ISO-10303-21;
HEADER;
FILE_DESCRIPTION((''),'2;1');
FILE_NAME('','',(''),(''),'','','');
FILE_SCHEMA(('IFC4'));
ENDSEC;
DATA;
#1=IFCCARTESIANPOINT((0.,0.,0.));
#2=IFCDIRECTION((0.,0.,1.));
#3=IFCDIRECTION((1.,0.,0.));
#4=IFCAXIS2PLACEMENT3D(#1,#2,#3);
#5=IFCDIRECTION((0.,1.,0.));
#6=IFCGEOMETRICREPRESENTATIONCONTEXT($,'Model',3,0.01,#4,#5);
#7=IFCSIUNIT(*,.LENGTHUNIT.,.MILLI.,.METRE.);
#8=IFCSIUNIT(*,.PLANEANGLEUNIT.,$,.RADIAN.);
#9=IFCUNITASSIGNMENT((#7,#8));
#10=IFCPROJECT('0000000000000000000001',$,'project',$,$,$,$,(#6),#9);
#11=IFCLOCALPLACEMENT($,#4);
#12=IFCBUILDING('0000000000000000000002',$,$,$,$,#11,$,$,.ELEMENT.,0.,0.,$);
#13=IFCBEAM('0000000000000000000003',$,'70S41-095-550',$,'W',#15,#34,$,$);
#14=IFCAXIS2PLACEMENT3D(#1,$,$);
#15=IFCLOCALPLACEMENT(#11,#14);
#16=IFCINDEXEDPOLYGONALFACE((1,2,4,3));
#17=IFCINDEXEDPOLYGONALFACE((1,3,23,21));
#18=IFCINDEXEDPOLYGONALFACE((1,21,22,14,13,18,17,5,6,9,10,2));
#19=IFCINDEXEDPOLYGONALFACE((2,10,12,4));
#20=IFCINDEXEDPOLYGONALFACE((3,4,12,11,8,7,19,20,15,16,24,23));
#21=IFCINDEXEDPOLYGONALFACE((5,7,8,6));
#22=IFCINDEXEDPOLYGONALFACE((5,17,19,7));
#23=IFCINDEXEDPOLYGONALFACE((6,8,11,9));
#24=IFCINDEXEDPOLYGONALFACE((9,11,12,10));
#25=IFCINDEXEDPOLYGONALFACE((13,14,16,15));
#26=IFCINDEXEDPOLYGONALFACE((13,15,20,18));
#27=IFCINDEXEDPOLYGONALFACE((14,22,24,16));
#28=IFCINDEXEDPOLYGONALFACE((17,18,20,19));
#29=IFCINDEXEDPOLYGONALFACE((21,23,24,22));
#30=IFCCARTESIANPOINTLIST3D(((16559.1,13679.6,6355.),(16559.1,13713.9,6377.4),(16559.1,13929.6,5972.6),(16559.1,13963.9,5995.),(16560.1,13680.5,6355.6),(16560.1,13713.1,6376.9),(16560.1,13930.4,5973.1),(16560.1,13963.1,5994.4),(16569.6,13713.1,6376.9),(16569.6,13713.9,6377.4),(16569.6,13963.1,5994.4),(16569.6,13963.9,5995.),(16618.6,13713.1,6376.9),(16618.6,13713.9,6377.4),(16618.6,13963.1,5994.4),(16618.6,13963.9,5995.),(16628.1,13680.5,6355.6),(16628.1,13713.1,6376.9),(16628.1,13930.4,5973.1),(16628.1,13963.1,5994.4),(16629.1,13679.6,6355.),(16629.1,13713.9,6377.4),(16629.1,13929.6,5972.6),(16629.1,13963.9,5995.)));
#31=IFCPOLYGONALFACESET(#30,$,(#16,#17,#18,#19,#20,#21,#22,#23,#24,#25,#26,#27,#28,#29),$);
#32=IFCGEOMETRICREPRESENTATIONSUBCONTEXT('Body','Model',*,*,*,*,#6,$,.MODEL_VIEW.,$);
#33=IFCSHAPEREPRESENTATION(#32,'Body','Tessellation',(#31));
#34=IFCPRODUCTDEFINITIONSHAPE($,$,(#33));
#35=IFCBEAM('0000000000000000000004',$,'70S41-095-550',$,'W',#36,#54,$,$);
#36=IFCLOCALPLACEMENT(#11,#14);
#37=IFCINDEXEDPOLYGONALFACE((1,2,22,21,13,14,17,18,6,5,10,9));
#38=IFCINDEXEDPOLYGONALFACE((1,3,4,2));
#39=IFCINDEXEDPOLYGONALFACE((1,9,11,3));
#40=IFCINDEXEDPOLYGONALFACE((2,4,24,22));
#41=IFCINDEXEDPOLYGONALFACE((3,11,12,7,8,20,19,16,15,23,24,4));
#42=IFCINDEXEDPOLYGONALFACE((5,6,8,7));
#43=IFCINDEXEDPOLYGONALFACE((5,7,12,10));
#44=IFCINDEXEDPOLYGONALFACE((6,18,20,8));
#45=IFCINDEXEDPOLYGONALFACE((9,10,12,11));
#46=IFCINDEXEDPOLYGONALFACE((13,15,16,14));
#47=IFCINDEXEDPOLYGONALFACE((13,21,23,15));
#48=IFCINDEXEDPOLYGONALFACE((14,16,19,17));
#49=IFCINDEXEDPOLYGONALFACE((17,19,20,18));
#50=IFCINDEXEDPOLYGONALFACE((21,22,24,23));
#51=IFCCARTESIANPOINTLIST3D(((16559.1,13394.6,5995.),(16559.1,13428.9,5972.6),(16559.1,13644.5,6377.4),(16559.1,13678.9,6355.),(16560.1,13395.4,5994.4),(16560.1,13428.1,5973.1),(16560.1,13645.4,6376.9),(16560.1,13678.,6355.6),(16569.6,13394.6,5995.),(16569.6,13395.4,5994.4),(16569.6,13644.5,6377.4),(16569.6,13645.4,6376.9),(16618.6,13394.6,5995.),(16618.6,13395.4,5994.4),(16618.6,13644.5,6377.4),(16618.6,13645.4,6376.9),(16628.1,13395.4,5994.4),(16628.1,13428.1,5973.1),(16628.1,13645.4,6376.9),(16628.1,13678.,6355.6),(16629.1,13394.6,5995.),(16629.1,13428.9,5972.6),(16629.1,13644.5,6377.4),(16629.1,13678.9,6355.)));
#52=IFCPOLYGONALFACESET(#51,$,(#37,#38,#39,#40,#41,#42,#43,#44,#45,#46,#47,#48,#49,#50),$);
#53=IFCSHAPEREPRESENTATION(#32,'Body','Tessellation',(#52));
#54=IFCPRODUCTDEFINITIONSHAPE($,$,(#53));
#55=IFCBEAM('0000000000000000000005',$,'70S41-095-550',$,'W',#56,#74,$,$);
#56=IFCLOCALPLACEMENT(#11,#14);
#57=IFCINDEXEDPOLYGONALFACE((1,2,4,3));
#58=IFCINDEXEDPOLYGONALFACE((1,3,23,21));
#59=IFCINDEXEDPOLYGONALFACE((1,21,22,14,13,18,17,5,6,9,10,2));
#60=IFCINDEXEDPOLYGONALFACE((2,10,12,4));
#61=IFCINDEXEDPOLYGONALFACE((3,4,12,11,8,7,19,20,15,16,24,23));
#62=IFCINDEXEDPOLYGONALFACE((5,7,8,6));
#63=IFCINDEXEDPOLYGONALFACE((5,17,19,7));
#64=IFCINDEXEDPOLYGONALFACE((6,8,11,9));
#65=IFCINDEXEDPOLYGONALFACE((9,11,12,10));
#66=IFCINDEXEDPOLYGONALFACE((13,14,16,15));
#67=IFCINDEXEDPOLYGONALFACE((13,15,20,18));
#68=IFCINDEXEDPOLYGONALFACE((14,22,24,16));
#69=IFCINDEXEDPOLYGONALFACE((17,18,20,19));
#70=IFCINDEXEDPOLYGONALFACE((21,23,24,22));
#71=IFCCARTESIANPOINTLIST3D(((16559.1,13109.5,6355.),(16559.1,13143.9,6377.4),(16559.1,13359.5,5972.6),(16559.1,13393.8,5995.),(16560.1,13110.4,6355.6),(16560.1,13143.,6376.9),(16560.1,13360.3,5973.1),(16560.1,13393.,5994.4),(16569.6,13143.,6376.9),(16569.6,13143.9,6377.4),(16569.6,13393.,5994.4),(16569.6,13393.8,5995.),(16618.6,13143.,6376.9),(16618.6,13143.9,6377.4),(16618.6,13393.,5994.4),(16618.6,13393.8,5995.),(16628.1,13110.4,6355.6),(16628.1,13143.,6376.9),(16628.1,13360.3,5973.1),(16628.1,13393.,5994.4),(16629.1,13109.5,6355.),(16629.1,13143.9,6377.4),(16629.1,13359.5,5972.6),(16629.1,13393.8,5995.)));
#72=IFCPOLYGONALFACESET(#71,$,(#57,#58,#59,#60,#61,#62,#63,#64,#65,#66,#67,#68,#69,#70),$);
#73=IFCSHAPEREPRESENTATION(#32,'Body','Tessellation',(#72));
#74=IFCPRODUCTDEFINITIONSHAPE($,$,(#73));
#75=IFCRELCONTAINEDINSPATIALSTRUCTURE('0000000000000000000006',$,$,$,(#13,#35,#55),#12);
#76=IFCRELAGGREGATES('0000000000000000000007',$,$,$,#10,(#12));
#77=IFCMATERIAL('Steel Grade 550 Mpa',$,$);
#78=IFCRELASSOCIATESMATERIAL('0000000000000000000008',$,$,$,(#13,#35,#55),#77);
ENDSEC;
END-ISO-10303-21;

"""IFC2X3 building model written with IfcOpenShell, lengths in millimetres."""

from ifc_helpers import new_model, si_unit, direction, frame, origin, origin_with_axes, origin_2d_with_axis, place, context, subcontext, project, spatial, c_section, extrude, source, transform, mapped, material, element, save


model = new_model("IFC2X3")

# Units and contexts
model_context = context("Model", 3, precision=0.01, world=origin_with_axes(), true_north=direction((0.0, 1.0, 0.0)))
body_context = subcontext(model_context, "Body", "Model", "MODEL_VIEW")
ifc_project = project(units=[si_unit("LENGTHUNIT", "METRE", prefix="MILLI"), si_unit("PLANEANGLEUNIT", "RADIAN")], contexts=[model_context])

# Building
building_placement = place(None, origin_with_axes())
building = spatial("IfcBuilding", under=ifc_project, at=building_placement, CompositionType="ELEMENT", ElevationOfRefHeight=0.0, ElevationOfTerrain=0.0)

# Shared definitions
ifc_material = material(Name="Steel Grade 550 Mpa")

# Beams
shared_shape_1 = source(origin(), body_context, "Body", "SweptSolid", [
    extrude(c_section(Depth=70.0, Width=41.0, WallThickness=1.0, Girth=10.5, at=origin_2d_with_axis()), origin_with_axes(), (0.0, 0.0, 1.0), 456.9),
])
beam_1_placement = place(None, frame((16594.1, 13696.8, 6366.2), z_axis=(0.0, 0.547116, -0.837057), x_axis=(0.0, 0.837057, 0.547116)))
element("IfcBeam", 1, at=beam_1_placement, inside=building, material=ifc_material, Name="70S41-095-550", ObjectType="W", context=body_context, shape_type="MappedRepresentation", body=[
    mapped(shared_shape_1, transform((0.0, 0.0, 0.0), scale=1.0)),
])
shared_shape_2 = source(origin(), body_context, "Body", "SweptSolid", [
    extrude(c_section(Depth=70.0, Width=41.0, WallThickness=1.0, Girth=10.5, at=origin_2d_with_axis()), origin_with_axes(), (0.0, 0.0, 1.0), 456.9),
])
beam_2_placement = place(None, frame((16594.1, 13411.7, 5983.8), z_axis=(0.0, 0.547116, 0.837057), x_axis=(0.0, -0.837057, 0.547116)))
element("IfcBeam", 2, at=beam_2_placement, inside=building, material=ifc_material, Name="70S41-095-550", ObjectType="W", context=body_context, shape_type="MappedRepresentation", body=[
    mapped(shared_shape_2, transform((0.0, 0.0, 0.0), scale=1.0)),
])
shared_shape_3 = source(origin(), body_context, "Body", "SweptSolid", [
    extrude(c_section(Depth=70.0, Width=41.0, WallThickness=1.0, Girth=10.5, at=origin_2d_with_axis()), origin_with_axes(), (0.0, 0.0, 1.0), 456.9),
])
beam_3_placement = place(None, frame((16594.1, 13126.7, 6366.2), z_axis=(0.0, 0.547116, -0.837057), x_axis=(0.0, 0.837057, 0.547116)))
element("IfcBeam", 3, at=beam_3_placement, inside=building, material=ifc_material, Name="70S41-095-550", ObjectType="W", context=body_context, shape_type="MappedRepresentation", body=[
    mapped(shared_shape_3, transform((0.0, 0.0, 0.0), scale=1.0)),
])

save(model, "model.ifc")
